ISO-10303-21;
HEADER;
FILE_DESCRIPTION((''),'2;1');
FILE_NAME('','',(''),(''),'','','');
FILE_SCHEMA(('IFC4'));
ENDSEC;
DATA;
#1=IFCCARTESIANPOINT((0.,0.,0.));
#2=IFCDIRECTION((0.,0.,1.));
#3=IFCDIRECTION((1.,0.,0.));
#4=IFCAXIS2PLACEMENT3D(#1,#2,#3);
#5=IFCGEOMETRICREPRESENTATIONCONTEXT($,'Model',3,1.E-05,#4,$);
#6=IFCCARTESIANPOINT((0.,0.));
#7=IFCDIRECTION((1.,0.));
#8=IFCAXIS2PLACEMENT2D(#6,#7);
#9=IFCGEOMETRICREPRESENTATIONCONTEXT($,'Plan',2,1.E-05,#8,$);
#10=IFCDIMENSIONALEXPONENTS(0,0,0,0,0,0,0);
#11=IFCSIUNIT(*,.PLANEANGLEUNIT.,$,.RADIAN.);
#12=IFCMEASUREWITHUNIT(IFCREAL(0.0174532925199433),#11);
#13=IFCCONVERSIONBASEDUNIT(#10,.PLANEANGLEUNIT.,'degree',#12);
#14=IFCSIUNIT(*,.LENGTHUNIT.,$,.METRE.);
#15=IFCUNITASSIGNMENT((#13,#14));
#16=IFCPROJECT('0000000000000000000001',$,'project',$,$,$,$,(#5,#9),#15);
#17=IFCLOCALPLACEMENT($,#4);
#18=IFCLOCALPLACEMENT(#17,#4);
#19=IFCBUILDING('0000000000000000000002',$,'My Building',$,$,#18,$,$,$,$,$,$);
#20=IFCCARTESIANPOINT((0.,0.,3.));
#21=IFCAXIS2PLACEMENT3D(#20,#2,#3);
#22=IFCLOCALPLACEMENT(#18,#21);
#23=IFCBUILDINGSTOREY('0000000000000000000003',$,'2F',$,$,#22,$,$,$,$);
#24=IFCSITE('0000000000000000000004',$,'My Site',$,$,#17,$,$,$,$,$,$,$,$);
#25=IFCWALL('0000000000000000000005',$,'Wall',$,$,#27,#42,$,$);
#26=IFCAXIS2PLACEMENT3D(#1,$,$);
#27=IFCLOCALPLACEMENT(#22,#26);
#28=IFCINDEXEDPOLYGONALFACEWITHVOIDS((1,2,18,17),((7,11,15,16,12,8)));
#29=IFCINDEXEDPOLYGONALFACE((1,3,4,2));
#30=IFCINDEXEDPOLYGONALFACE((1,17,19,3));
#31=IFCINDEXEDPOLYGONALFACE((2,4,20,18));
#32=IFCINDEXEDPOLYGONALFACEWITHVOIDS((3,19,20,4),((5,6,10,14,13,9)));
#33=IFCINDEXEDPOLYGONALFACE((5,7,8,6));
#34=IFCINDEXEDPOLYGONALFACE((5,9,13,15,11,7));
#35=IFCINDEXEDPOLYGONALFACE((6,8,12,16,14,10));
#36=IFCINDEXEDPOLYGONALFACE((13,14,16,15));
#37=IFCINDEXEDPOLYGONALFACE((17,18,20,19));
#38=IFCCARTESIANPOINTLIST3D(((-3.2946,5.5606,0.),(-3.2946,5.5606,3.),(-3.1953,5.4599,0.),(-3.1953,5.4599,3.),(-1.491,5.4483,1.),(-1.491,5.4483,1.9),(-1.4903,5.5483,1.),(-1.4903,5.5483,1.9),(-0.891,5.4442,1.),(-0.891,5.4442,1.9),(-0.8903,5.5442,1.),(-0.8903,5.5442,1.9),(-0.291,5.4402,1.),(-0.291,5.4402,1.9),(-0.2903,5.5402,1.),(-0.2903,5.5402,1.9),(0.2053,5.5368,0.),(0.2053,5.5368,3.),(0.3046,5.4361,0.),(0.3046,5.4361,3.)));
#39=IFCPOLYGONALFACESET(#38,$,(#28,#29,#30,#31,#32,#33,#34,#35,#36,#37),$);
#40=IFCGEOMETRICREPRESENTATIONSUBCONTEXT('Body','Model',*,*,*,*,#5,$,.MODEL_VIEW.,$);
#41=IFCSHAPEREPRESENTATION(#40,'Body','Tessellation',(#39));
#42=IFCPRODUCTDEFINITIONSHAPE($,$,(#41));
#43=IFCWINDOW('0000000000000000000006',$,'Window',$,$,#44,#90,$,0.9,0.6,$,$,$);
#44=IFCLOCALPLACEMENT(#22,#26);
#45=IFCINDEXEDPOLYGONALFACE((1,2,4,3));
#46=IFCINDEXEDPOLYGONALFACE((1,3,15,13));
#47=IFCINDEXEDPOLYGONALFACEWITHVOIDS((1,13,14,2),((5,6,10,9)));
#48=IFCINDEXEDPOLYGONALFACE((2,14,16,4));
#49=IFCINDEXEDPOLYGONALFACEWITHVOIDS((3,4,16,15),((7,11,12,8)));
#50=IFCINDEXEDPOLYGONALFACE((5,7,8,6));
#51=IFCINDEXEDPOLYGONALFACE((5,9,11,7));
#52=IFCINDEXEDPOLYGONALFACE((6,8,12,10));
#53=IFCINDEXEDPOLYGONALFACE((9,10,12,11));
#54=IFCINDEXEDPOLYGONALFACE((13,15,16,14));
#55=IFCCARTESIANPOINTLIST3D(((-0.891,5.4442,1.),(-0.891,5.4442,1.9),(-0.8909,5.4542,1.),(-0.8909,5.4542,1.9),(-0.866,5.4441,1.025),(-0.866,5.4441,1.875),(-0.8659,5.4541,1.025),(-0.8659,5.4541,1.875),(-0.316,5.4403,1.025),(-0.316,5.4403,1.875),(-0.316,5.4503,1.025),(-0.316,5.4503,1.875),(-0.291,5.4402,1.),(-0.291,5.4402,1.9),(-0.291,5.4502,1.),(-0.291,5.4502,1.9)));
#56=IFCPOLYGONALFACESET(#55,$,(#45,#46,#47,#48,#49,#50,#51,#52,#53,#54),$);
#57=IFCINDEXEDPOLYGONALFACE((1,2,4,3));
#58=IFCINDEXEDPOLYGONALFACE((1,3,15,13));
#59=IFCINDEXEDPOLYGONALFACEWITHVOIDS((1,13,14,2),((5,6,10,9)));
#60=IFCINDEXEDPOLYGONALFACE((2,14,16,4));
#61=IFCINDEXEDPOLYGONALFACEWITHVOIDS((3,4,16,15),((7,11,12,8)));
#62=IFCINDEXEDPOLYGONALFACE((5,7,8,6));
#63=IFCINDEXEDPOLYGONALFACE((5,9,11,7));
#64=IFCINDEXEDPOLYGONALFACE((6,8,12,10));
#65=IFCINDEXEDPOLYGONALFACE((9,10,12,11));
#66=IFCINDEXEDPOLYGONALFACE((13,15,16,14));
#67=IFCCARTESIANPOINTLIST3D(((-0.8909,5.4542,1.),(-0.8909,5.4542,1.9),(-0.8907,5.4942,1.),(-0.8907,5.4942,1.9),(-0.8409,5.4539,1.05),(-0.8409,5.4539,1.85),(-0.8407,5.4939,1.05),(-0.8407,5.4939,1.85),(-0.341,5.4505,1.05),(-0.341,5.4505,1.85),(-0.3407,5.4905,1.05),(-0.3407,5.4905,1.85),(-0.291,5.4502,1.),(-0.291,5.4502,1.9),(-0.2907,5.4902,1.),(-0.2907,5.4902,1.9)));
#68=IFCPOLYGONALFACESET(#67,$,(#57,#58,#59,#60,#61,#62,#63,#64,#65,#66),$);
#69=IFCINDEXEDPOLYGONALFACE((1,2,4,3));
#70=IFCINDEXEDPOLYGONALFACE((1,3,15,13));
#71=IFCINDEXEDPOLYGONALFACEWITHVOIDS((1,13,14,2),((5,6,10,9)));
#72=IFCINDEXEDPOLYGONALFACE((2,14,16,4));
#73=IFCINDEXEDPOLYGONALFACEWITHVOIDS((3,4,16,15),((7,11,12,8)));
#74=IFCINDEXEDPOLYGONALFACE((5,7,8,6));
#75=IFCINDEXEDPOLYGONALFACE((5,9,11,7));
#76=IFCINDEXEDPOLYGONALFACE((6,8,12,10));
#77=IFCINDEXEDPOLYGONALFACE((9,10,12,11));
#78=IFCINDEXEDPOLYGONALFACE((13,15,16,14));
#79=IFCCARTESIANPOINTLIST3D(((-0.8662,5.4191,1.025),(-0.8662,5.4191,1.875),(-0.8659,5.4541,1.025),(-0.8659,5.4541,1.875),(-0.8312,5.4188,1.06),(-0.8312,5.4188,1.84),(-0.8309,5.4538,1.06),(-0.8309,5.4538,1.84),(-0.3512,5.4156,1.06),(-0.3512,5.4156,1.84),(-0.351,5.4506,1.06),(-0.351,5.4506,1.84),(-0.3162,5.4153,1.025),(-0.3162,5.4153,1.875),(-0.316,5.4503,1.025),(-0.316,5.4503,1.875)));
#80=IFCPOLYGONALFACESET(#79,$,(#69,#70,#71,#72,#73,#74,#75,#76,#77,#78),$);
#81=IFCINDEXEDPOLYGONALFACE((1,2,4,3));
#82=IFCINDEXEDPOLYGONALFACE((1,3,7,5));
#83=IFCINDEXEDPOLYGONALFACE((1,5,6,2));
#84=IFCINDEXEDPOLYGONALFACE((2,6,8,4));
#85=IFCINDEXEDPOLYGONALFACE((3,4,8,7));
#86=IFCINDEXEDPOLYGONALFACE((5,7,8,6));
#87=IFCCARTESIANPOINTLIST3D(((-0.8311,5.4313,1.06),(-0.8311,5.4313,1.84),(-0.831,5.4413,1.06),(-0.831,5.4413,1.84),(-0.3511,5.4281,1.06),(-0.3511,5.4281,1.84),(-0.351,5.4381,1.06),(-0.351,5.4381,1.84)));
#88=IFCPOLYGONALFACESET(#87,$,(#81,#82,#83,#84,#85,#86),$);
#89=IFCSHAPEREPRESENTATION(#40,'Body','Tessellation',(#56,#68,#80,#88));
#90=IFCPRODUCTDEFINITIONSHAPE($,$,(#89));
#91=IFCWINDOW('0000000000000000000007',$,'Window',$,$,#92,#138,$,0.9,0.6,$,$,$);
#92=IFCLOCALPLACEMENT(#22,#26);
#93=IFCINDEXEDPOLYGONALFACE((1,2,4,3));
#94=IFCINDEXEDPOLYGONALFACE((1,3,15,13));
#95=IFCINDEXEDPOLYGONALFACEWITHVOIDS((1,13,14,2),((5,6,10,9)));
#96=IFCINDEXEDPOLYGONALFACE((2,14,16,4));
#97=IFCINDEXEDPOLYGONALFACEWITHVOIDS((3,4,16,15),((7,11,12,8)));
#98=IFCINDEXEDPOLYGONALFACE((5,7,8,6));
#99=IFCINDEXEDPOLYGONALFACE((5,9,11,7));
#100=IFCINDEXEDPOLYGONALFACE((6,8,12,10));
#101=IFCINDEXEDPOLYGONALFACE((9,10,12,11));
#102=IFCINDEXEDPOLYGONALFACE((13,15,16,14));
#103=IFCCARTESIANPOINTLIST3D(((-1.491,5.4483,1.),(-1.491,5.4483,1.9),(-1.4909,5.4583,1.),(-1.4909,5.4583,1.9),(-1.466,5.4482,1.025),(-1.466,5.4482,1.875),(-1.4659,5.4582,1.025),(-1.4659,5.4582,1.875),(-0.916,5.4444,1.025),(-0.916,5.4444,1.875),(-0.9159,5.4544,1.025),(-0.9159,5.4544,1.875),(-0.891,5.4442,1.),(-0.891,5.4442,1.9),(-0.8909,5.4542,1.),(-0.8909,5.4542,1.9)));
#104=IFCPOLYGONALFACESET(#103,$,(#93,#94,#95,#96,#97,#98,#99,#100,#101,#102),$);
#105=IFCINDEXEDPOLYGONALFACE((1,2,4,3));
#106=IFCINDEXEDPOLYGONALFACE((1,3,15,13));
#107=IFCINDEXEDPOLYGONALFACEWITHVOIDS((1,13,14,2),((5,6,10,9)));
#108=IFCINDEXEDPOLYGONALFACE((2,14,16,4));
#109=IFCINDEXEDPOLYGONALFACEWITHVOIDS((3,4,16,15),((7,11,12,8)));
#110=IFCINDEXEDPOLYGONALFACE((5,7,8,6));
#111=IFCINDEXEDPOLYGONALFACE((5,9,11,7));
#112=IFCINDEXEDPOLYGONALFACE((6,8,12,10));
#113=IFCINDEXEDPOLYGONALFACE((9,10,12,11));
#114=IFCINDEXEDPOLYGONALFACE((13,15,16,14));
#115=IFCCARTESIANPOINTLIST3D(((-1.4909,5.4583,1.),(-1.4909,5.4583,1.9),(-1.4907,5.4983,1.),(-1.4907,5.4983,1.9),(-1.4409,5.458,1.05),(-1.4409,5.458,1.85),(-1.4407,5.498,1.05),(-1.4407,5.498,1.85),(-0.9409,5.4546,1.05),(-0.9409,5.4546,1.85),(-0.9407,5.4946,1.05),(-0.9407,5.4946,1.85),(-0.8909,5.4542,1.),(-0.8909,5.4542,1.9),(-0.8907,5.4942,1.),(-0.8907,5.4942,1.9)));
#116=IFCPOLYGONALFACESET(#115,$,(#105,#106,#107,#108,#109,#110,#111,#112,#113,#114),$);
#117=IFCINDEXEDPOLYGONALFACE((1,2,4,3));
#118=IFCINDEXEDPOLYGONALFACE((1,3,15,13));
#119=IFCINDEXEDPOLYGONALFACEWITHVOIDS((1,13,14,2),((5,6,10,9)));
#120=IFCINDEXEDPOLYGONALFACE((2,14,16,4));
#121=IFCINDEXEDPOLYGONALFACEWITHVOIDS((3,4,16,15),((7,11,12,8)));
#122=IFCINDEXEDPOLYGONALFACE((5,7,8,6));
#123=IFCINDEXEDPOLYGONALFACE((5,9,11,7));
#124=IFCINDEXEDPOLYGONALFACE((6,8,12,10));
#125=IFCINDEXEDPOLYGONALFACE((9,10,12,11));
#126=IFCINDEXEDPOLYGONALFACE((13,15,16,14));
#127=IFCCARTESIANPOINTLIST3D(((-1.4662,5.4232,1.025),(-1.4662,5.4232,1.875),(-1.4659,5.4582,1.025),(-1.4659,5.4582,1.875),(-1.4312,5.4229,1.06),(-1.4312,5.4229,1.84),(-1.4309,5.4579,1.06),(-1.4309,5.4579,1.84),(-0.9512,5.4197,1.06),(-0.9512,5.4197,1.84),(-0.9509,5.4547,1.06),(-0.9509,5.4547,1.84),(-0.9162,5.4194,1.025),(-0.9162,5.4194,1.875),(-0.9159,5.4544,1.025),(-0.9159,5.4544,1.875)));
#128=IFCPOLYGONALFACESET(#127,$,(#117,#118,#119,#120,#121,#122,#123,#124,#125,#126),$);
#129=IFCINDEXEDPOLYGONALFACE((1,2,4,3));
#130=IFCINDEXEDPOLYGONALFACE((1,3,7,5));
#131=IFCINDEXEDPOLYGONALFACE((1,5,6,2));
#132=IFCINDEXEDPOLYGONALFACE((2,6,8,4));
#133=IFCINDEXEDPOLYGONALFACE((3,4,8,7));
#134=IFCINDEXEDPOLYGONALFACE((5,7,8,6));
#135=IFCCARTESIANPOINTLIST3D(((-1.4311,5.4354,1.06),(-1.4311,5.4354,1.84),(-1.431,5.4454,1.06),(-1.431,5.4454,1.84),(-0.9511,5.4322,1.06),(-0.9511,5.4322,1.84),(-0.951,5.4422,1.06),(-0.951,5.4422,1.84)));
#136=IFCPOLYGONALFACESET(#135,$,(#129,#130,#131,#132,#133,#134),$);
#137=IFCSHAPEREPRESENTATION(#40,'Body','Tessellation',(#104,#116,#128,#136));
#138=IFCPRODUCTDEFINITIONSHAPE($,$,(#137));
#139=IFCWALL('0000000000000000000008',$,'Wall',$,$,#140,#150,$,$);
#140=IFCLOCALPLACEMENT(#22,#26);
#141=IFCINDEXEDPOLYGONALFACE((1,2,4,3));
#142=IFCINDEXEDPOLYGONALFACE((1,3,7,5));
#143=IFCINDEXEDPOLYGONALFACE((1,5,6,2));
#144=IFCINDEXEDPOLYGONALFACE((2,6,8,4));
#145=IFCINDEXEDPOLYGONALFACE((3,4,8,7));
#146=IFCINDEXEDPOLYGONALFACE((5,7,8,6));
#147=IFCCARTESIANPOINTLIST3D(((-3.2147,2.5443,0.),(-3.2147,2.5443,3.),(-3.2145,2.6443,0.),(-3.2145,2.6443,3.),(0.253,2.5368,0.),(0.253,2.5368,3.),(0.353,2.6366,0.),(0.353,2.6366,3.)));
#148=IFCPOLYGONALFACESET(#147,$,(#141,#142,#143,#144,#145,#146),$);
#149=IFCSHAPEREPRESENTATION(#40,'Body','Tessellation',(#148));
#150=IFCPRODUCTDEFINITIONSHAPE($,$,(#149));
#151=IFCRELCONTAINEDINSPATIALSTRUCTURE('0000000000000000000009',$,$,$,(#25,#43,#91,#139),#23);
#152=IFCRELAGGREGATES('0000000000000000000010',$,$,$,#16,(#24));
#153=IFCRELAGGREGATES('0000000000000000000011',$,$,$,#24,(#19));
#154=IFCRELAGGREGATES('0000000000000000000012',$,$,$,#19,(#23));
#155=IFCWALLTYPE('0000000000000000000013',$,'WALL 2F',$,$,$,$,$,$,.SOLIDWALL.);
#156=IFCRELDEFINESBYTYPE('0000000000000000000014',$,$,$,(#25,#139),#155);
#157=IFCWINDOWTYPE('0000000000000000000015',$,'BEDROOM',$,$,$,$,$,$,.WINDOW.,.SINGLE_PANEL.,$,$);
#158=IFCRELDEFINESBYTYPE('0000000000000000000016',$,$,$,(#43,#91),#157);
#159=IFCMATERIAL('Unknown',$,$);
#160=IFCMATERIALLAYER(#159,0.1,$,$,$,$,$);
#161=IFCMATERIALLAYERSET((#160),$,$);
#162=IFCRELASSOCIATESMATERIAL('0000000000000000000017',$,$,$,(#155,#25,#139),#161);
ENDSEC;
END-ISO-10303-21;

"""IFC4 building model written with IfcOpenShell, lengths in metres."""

from ifc_helpers import new_model, entity, si_unit, converted_unit, frame, origin_with_axes, origin_2d_with_axis, place, context, subcontext, project, spatial, line, indexed_curve, outline, extrude, shape, source, transform, mapped, material, layer, layer_set, layer_usage, type_object, type_shapes, element, fill, save


model = new_model("IFC4")

# Units and contexts
model_context = context("Model", 3, precision=1e-05, world=origin_with_axes())
plan_context = context("Plan", 2, precision=1e-05, world=origin_2d_with_axis())
body_context_1 = subcontext(model_context, "Body", "Model", "MODEL_VIEW")
body_context_2 = subcontext(plan_context, "Body", "Plan", "PLAN_VIEW")
ifc_project = project(units=[converted_unit("PLANEANGLEUNIT", "degree", entity("IfcReal", 0.0174532925199433), si_unit("PLANEANGLEUNIT", "RADIAN"), dimensions=[0, 0, 0, 0, 0, 0, 0]), si_unit("LENGTHUNIT", "METRE")], contexts=[model_context, plan_context])

# Site, building, storey
site_placement = place(None, origin_with_axes())
site = spatial("IfcSite", under=ifc_project, at=site_placement, Name="My Site")
building_placement = place(site_placement, origin_with_axes())
building = spatial("IfcBuilding", under=site, at=building_placement, Name="My Building")
storey_placement = place(building_placement, frame((0.0, 0.0, 3.0), z_axis=(0.0, 0.0, 1.0), x_axis=(1.0, 0.0, 0.0)))
storey = spatial("IfcBuildingStorey", under=building, at=storey_placement, Name="2F")

# Shared definitions
ifc_material = material(Name="Unknown")

# Shared definitions
ifc_layer_1 = layer(ifc_material, 0.1)
ifc_layer_set_1 = layer_set([ifc_layer_1])
wall_type = type_object("IfcWallType", Name="WALL 2F", PredefinedType="SOLIDWALL", material=ifc_layer_set_1)

# Wall, openings, windows
ifc_layer_usage_1 = layer_usage(ifc_layer_set_1, "AXIS2", "POSITIVE", 0.0)
wall_1_placement = place(storey_placement, frame((0.2053, 5.5368, 0.0), z_axis=(0.0, 0.0, 1.0), x_axis=(-0.999977, 0.006815, 0.0)))
wall_1 = element("IfcWall", 1, at=wall_1_placement, inside=storey, type_object=wall_type, material=ifc_layer_usage_1, Name="Wall", context=body_context_1, shape_type="SweptSolid", body=[
    extrude(outline(indexed_curve([(0.0, 0.0), (-0.1, 0.1), (3.4, 0.1), (3.5, 0.0)], segments=[line(1, 2, 3, 4, 1)])), origin_with_axes(), (0.0, 0.0, 1.0), 3.0),
])
shared_shape_1 = source(origin_with_axes(), body_context_1, "Body", "SweptSolid", [
    extrude(outline(indexed_curve([(0.0, 0.0), (0.6, 0.0), (0.6, 0.9), (0.0, 0.9)], segments=[line(1, 2, 3, 4, 1)])), frame((0.0, -0.6, 0.0), z_axis=(0.0, -1.0, 0.0), x_axis=(1.0, 0.0, 0.0)), (0.0, 0.0, -1.0), 1.2),
])
opening_1_placement = place(wall_1_placement, frame((0.4957, 0.0, 1.0), z_axis=(0.0, 0.0, 1.0), x_axis=(1.0, 0.0, 0.0)))
opening_1 = element("IfcOpeningElement", 2, at=opening_1_placement, cuts=wall_1, PredefinedType="OPENING", context=body_context_1, shape_type="MappedRepresentation", body=[
    mapped(shared_shape_1, transform((0.0, 0.0, 0.0), x_axis=(1.0, 0.0, 0.0), y_axis=(0.0, 1.0, 0.0), z_axis=(0.0, 0.0, 1.0), scale=1.0)),
])
opening_2_placement = place(wall_1_placement, frame((1.0957, 0.0, 1.0), z_axis=(0.0, 0.0, 1.0), x_axis=(1.0, 0.0, 0.0)))
opening_2 = element("IfcOpeningElement", 3, at=opening_2_placement, cuts=wall_1, PredefinedType="OPENING", context=body_context_1, shape_type="MappedRepresentation", body=[
    mapped(shared_shape_1, transform((0.0, 0.0, 0.0), x_axis=(1.0, 0.0, 0.0), y_axis=(0.0, 1.0, 0.0), z_axis=(0.0, 0.0, 1.0), scale=1.0)),
])
window_type = type_object("IfcWindowType", Name="BEDROOM", PartitioningType="SINGLE_PANEL", PredefinedType="WINDOW")
shared_shape_2 = source(origin_with_axes(), body_context_1, "Body", "SweptSolid", [
    extrude(outline(indexed_curve([(0.0, 0.0), (0.6, 0.0), (0.6, 0.9), (0.0, 0.9)], segments=[line(1, 2, 3, 4, 1)]), holes=[indexed_curve([(0.025, 0.025), (0.575, 0.025), (0.575, 0.875), (0.025, 0.875)], segments=[line(1, 2, 3, 4, 1)])]), frame((0.0, 0.09, 0.0), z_axis=(0.0, -1.0, 0.0), x_axis=(1.0, 0.0, 0.0)), (0.0, 0.0, -1.0), 0.01),
    extrude(outline(indexed_curve([(0.0, 0.0), (0.6, 0.0), (0.6, 0.9), (0.0, 0.9)], segments=[line(1, 2, 3, 4, 1)]), holes=[indexed_curve([(0.05, 0.05), (0.55, 0.05), (0.55, 0.85), (0.05, 0.85)], segments=[line(1, 2, 3, 4, 1)])]), frame((0.0, 0.05, 0.0), z_axis=(0.0, -1.0, 0.0), x_axis=(1.0, 0.0, 0.0)), (0.0, 0.0, -1.0), 0.04),
    extrude(outline(indexed_curve([(0.0, 0.0), (0.55, 0.0), (0.55, 0.85), (0.0, 0.85)], segments=[line(1, 2, 3, 4, 1)]), holes=[indexed_curve([(0.035, 0.035), (0.515, 0.035), (0.515, 0.815), (0.035, 0.815)], segments=[line(1, 2, 3, 4, 1)])]), frame((0.025, 0.09, 0.025), z_axis=(0.0, -1.0, 0.0), x_axis=(1.0, 0.0, 0.0)), (0.0, 0.0, -1.0), 0.035),
    extrude(outline(indexed_curve([(0.035, 0.035), (0.515, 0.035), (0.515, 0.815), (0.035, 0.815)], segments=[line(1, 2, 3, 4, 1)])), frame((0.025, 0.1025, 0.025), z_axis=(0.0, -1.0, 0.0), x_axis=(1.0, 0.0, 0.0)), (0.0, 0.0, -1.0), 0.01),
])
shared_shape_3 = source(origin_with_axes(), body_context_2, "Body", "Curve2D", [
    entity("IfcIndexedPolyCurve", entity("IfcCartesianPointList2D", [[0.05, 0.05], [0.55, 0.05]])),
    entity("IfcIndexedPolyCurve", entity("IfcCartesianPointList2D", [[0.0, 0.1], [0.025, 0.1], [0.025, 0.09], [0.05, 0.09], [0.05, 0.05], [0.0, 0.05]]), [entity("IfcLineIndex", [1, 2, 3, 4, 5, 6, 1])]),
    entity("IfcIndexedPolyCurve", entity("IfcCartesianPointList2D", [[0.6, 0.1], [0.575, 0.1], [0.575, 0.09], [0.55, 0.09], [0.55, 0.05], [0.6, 0.05]]), [entity("IfcLineIndex", [1, 2, 3, 4, 5, 6, 1])]),
    entity("IfcIndexedPolyCurve", entity("IfcCartesianPointList2D", [[0.025, 0.09], [0.06, 0.09], [0.06, 0.125], [0.025, 0.125]]), [entity("IfcLineIndex", [1, 2, 3, 4, 1])]),
    entity("IfcIndexedPolyCurve", entity("IfcCartesianPointList2D", [[0.575, 0.09], [0.54, 0.09], [0.54, 0.125], [0.575, 0.125]]), [entity("IfcLineIndex", [1, 2, 3, 4, 1])]),
    entity("IfcIndexedPolyCurve", entity("IfcCartesianPointList2D", [[0.06, 0.09], [0.54, 0.09]])),
    entity("IfcIndexedPolyCurve", entity("IfcCartesianPointList2D", [[0.06, 0.125], [0.54, 0.125]])),
    entity("IfcIndexedPolyCurve", entity("IfcCartesianPointList2D", [[0.06, 0.1075], [0.54, 0.1075]])),
])
type_shapes(window_type, [shared_shape_2, shared_shape_3])
window_1_placement = place(opening_1_placement, frame((0.0, 0.0, 0.0), z_axis=(0.0, 0.0, 1.0), x_axis=(1.0, 0.0, 0.0)))
window_1 = element("IfcWindow", 4, at=window_1_placement, inside=storey, type_object=window_type, Name="Window", OverallHeight=0.9, OverallWidth=0.6, shapes=[
    shape(body_context_1, "Body", "MappedRepresentation", [mapped(shared_shape_2, transform((0.0, 0.0, 0.0), x_axis=(1.0, 0.0, 0.0), y_axis=(0.0, 1.0, 0.0), z_axis=(0.0, 0.0, 1.0), scale=1.0))]),
    shape(body_context_2, "Body", "MappedRepresentation", [mapped(shared_shape_3, transform((0.0, 0.0, 0.0), x_axis=(1.0, 0.0, 0.0), y_axis=(0.0, 1.0, 0.0), z_axis=(0.0, 0.0, 1.0), scale=1.0))]),
])
fill(opening_1, window_1)
window_2_placement = place(opening_2_placement, frame((0.0, 0.0, 0.0), z_axis=(0.0, 0.0, 1.0), x_axis=(1.0, 0.0, 0.0)))
window_2 = element("IfcWindow", 5, at=window_2_placement, inside=storey, type_object=window_type, Name="Window", OverallHeight=0.9, OverallWidth=0.6, shapes=[
    shape(body_context_1, "Body", "MappedRepresentation", [mapped(shared_shape_2, transform((0.0, 0.0, 0.0), x_axis=(1.0, 0.0, 0.0), y_axis=(0.0, 1.0, 0.0), z_axis=(0.0, 0.0, 1.0), scale=1.0))]),
    shape(body_context_2, "Body", "MappedRepresentation", [mapped(shared_shape_3, transform((0.0, 0.0, 0.0), x_axis=(1.0, 0.0, 0.0), y_axis=(0.0, 1.0, 0.0), z_axis=(0.0, 0.0, 1.0), scale=1.0))]),
])
fill(opening_2, window_2)

# Wall
ifc_layer_usage_2 = layer_usage(ifc_layer_set_1, "AXIS2", "POSITIVE", 0.0)
wall_2_placement = place(storey_placement, frame((0.353, 2.6366, 0.0), z_axis=(0.0, 0.0, 1.0), x_axis=(-0.999998, 0.002185, 0.0)))
element("IfcWall", 6, at=wall_2_placement, inside=storey, type_object=wall_type, material=ifc_layer_usage_2, Name="Wall", context=body_context_1, shape_type="SweptSolid", body=[
    extrude(outline(indexed_curve([(0.0, 0.0), (0.0998, 0.1), (3.5675, 0.1), (3.5675, 0.0)], segments=[line(1, 2, 3, 4, 1)])), origin_with_axes(), (0.0, 0.0, 1.0), 3.0),
])

save(model, "model.ifc")
